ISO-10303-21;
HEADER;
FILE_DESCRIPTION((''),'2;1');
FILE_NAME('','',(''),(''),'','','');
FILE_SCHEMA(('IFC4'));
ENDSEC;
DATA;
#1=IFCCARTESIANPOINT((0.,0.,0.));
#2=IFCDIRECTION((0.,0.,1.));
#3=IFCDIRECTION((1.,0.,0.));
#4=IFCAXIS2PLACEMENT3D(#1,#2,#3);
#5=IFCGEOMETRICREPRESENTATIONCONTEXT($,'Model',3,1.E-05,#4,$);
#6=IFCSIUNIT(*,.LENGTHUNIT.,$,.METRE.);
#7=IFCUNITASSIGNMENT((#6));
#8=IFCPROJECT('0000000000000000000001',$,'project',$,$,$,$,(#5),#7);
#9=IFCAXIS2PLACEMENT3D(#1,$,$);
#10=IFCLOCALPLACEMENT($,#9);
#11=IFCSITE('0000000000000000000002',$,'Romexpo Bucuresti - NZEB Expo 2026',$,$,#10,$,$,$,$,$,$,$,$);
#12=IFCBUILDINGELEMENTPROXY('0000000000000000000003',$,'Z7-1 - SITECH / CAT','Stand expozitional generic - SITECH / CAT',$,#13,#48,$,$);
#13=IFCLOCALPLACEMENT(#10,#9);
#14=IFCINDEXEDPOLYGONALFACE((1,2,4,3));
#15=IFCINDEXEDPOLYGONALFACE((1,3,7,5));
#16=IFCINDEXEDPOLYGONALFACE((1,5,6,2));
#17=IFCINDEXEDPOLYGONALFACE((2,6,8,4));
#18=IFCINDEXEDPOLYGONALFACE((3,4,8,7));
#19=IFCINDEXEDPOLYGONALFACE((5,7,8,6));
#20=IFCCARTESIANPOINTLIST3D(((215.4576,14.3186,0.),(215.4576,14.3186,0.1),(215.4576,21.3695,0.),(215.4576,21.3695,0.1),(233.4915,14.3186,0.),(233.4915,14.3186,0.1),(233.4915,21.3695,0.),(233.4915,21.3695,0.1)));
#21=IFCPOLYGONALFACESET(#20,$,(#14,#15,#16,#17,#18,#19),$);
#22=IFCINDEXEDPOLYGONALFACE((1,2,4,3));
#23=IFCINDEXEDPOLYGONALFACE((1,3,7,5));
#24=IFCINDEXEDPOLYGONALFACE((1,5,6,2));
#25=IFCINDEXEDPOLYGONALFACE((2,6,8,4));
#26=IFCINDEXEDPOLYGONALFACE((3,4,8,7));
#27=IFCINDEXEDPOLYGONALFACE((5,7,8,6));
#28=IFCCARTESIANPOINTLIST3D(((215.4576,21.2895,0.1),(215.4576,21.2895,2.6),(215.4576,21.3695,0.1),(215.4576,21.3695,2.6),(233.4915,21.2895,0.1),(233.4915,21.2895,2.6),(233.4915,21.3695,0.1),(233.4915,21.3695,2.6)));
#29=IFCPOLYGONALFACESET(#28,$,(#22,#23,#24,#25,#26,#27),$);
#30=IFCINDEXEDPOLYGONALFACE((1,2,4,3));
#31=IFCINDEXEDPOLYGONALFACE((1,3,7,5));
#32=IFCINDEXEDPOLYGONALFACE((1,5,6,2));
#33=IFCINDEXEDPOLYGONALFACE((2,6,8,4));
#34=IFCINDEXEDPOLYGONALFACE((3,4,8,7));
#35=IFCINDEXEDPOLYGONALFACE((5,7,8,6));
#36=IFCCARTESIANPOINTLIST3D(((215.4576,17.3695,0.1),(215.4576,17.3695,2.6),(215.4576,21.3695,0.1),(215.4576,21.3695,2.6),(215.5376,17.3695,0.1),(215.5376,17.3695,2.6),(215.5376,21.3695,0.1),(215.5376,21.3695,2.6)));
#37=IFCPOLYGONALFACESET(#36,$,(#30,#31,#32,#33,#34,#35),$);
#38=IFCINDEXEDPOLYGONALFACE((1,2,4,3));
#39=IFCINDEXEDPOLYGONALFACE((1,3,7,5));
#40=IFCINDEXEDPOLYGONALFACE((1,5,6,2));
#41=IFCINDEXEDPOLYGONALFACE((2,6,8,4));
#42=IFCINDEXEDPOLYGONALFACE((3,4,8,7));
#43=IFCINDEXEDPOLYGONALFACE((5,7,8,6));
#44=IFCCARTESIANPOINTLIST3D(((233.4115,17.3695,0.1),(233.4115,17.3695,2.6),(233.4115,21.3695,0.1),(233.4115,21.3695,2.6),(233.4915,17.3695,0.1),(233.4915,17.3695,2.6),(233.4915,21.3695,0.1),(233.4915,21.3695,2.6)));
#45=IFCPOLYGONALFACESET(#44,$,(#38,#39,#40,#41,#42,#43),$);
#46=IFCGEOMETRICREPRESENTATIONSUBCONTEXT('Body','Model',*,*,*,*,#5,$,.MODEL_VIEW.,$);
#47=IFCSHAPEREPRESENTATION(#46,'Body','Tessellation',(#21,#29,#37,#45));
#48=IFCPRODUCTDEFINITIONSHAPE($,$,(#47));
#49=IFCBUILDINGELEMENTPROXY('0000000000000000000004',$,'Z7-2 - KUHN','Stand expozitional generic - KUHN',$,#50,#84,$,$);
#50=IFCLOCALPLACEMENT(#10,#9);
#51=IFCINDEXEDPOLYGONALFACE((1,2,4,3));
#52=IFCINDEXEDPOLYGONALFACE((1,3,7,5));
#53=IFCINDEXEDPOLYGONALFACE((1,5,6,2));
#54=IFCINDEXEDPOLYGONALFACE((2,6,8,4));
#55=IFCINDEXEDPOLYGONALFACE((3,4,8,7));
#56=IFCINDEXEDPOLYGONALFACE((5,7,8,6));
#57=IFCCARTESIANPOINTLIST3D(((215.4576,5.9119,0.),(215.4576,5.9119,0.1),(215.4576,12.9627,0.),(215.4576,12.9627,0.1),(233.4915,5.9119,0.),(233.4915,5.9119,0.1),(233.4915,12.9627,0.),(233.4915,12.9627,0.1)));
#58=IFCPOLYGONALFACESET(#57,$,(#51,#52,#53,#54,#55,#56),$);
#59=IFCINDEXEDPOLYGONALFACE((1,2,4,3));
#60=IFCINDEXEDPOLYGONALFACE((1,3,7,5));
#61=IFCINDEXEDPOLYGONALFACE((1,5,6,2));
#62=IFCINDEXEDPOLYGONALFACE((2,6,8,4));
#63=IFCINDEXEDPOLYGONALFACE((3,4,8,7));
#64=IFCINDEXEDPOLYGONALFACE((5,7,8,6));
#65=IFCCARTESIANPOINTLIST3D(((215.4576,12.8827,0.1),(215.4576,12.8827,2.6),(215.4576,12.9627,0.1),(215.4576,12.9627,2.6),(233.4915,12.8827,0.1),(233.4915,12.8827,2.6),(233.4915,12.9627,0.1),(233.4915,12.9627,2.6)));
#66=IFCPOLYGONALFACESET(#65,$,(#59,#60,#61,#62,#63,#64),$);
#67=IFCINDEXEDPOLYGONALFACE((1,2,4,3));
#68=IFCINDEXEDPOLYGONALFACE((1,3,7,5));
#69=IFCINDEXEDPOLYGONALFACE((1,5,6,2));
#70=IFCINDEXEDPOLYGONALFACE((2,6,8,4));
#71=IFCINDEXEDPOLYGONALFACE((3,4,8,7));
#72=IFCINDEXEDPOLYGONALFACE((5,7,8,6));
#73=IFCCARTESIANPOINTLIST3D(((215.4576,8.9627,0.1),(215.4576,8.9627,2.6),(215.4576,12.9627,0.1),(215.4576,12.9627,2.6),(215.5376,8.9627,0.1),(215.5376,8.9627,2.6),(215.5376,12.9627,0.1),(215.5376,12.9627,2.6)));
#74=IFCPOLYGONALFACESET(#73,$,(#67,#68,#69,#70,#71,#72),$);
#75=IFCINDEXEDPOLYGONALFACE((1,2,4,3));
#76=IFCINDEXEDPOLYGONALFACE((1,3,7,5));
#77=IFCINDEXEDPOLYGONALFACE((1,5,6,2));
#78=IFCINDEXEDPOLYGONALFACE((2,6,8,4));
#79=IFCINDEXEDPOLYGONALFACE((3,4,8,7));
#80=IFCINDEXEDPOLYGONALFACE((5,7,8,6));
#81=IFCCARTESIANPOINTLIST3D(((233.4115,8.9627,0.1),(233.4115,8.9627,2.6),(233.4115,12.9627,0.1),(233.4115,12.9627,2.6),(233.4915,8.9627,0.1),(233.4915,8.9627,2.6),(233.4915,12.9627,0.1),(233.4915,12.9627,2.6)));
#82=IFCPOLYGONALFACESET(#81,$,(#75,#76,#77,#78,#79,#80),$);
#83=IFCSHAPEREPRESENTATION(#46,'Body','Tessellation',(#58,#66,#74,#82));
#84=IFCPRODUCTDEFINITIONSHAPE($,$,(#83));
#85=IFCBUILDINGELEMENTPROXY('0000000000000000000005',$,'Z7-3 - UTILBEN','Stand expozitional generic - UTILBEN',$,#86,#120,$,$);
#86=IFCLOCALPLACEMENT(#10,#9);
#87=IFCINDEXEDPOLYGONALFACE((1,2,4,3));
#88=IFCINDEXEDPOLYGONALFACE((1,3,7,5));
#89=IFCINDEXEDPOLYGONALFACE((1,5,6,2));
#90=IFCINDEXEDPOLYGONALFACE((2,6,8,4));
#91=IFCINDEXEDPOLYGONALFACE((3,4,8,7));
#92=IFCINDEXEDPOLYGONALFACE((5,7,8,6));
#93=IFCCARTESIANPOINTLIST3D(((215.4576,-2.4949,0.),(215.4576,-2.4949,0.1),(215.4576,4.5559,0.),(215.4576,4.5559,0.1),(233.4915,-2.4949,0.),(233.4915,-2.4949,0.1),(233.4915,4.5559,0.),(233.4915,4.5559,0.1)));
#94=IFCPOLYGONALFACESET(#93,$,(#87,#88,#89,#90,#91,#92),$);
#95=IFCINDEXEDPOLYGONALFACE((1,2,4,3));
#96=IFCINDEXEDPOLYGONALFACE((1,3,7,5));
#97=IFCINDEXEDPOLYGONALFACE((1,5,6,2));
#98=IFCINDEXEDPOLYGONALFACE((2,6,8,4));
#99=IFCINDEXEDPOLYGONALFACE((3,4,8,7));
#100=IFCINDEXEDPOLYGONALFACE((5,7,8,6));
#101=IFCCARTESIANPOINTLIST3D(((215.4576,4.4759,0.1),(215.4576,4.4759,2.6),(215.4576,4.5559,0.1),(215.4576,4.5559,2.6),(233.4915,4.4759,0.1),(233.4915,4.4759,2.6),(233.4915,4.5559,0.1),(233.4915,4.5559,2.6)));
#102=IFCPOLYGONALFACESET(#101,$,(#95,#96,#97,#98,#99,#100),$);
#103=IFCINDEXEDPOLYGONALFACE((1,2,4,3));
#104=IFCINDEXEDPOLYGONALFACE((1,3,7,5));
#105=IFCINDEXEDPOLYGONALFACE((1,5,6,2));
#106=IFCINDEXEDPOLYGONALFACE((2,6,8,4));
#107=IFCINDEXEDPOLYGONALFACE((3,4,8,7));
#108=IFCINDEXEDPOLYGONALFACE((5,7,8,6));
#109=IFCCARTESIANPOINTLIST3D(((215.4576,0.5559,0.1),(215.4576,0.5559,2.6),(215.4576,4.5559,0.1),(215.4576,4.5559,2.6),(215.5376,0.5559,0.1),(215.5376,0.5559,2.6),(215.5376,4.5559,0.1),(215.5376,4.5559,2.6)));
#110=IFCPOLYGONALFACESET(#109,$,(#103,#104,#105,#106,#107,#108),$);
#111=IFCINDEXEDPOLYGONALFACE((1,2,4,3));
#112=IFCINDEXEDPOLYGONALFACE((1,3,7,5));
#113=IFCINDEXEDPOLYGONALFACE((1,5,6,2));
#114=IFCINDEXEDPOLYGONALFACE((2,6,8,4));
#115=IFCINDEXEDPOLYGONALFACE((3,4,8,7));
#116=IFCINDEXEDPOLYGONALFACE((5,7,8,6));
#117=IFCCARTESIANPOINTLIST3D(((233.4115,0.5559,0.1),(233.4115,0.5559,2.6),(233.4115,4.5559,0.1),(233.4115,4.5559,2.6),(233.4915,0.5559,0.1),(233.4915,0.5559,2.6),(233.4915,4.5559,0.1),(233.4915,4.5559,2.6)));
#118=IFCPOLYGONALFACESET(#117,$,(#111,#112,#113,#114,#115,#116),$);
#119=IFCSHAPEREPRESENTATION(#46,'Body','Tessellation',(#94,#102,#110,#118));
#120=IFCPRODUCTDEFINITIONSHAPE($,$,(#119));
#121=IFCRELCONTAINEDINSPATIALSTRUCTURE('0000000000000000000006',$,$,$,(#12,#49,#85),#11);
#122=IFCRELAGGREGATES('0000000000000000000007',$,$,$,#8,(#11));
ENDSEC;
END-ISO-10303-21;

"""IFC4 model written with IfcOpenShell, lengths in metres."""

from ifc_helpers import new_model, si_unit, frame, frame_2d, origin, origin_with_axes, place, context, subcontext, project, spatial, rectangle, extrude, element, save


model = new_model("IFC4")

# Units and contexts
model_context = context("Model", 3, precision=1e-05, world=origin_with_axes())
body_context = subcontext(model_context, "Body", "Model", "MODEL_VIEW")
ifc_project = project(units=[si_unit("LENGTHUNIT", "METRE")], contexts=[model_context])

# Site
site_placement = place(None, origin())
site = spatial("IfcSite", under=ifc_project, at=site_placement, Name="Romexpo Bucuresti - NZEB Expo 2026")

# Building element proxies
for number, where, z_axis, x_axis, name, description in (
    (1, (215.4576, 14.3186, 0.0), (0.0, 0.0, 1.0), (1.0, 0.0, 0.0), "Z7-1 - SITECH / CAT", "Stand expozitional generic - SITECH / CAT"),
    (2, (215.4576, 5.9119, 0.0), (0.0, 0.0, 1.0), (1.0, 0.0, 0.0), "Z7-2 - KUHN", "Stand expozitional generic - KUHN"),
    (3, (215.4576, -2.4949, 0.0), (0.0, 0.0, 1.0), (1.0, 0.0, 0.0), "Z7-3 - UTILBEN", "Stand expozitional generic - UTILBEN"),
):
    element("IfcBuildingElementProxy", number, at=place(site_placement, frame(where, z_axis=z_axis, x_axis=x_axis)), inside=site, Name=name, Description=description, context=body_context, shape_type="SweptSolid", body=[
        extrude(rectangle(XDim=18.0339, YDim=7.0508, at=frame_2d((9.0169, 3.5254))), origin(), (0.0, 0.0, 1.0), 0.1),
        extrude(rectangle(XDim=18.0339, YDim=0.08, at=frame_2d((9.0169, 7.0108))), frame((0.0, 0.0, 0.1)), (0.0, 0.0, 1.0), 2.5),
        extrude(rectangle(XDim=0.08, YDim=4.0, at=frame_2d((0.04, 5.0508))), frame((0.0, 0.0, 0.1)), (0.0, 0.0, 1.0), 2.5),
        extrude(rectangle(XDim=0.08, YDim=4.0, at=frame_2d((17.9939, 5.0508))), frame((0.0, 0.0, 0.1)), (0.0, 0.0, 1.0), 2.5),
    ])

save(model, "model.ifc")
